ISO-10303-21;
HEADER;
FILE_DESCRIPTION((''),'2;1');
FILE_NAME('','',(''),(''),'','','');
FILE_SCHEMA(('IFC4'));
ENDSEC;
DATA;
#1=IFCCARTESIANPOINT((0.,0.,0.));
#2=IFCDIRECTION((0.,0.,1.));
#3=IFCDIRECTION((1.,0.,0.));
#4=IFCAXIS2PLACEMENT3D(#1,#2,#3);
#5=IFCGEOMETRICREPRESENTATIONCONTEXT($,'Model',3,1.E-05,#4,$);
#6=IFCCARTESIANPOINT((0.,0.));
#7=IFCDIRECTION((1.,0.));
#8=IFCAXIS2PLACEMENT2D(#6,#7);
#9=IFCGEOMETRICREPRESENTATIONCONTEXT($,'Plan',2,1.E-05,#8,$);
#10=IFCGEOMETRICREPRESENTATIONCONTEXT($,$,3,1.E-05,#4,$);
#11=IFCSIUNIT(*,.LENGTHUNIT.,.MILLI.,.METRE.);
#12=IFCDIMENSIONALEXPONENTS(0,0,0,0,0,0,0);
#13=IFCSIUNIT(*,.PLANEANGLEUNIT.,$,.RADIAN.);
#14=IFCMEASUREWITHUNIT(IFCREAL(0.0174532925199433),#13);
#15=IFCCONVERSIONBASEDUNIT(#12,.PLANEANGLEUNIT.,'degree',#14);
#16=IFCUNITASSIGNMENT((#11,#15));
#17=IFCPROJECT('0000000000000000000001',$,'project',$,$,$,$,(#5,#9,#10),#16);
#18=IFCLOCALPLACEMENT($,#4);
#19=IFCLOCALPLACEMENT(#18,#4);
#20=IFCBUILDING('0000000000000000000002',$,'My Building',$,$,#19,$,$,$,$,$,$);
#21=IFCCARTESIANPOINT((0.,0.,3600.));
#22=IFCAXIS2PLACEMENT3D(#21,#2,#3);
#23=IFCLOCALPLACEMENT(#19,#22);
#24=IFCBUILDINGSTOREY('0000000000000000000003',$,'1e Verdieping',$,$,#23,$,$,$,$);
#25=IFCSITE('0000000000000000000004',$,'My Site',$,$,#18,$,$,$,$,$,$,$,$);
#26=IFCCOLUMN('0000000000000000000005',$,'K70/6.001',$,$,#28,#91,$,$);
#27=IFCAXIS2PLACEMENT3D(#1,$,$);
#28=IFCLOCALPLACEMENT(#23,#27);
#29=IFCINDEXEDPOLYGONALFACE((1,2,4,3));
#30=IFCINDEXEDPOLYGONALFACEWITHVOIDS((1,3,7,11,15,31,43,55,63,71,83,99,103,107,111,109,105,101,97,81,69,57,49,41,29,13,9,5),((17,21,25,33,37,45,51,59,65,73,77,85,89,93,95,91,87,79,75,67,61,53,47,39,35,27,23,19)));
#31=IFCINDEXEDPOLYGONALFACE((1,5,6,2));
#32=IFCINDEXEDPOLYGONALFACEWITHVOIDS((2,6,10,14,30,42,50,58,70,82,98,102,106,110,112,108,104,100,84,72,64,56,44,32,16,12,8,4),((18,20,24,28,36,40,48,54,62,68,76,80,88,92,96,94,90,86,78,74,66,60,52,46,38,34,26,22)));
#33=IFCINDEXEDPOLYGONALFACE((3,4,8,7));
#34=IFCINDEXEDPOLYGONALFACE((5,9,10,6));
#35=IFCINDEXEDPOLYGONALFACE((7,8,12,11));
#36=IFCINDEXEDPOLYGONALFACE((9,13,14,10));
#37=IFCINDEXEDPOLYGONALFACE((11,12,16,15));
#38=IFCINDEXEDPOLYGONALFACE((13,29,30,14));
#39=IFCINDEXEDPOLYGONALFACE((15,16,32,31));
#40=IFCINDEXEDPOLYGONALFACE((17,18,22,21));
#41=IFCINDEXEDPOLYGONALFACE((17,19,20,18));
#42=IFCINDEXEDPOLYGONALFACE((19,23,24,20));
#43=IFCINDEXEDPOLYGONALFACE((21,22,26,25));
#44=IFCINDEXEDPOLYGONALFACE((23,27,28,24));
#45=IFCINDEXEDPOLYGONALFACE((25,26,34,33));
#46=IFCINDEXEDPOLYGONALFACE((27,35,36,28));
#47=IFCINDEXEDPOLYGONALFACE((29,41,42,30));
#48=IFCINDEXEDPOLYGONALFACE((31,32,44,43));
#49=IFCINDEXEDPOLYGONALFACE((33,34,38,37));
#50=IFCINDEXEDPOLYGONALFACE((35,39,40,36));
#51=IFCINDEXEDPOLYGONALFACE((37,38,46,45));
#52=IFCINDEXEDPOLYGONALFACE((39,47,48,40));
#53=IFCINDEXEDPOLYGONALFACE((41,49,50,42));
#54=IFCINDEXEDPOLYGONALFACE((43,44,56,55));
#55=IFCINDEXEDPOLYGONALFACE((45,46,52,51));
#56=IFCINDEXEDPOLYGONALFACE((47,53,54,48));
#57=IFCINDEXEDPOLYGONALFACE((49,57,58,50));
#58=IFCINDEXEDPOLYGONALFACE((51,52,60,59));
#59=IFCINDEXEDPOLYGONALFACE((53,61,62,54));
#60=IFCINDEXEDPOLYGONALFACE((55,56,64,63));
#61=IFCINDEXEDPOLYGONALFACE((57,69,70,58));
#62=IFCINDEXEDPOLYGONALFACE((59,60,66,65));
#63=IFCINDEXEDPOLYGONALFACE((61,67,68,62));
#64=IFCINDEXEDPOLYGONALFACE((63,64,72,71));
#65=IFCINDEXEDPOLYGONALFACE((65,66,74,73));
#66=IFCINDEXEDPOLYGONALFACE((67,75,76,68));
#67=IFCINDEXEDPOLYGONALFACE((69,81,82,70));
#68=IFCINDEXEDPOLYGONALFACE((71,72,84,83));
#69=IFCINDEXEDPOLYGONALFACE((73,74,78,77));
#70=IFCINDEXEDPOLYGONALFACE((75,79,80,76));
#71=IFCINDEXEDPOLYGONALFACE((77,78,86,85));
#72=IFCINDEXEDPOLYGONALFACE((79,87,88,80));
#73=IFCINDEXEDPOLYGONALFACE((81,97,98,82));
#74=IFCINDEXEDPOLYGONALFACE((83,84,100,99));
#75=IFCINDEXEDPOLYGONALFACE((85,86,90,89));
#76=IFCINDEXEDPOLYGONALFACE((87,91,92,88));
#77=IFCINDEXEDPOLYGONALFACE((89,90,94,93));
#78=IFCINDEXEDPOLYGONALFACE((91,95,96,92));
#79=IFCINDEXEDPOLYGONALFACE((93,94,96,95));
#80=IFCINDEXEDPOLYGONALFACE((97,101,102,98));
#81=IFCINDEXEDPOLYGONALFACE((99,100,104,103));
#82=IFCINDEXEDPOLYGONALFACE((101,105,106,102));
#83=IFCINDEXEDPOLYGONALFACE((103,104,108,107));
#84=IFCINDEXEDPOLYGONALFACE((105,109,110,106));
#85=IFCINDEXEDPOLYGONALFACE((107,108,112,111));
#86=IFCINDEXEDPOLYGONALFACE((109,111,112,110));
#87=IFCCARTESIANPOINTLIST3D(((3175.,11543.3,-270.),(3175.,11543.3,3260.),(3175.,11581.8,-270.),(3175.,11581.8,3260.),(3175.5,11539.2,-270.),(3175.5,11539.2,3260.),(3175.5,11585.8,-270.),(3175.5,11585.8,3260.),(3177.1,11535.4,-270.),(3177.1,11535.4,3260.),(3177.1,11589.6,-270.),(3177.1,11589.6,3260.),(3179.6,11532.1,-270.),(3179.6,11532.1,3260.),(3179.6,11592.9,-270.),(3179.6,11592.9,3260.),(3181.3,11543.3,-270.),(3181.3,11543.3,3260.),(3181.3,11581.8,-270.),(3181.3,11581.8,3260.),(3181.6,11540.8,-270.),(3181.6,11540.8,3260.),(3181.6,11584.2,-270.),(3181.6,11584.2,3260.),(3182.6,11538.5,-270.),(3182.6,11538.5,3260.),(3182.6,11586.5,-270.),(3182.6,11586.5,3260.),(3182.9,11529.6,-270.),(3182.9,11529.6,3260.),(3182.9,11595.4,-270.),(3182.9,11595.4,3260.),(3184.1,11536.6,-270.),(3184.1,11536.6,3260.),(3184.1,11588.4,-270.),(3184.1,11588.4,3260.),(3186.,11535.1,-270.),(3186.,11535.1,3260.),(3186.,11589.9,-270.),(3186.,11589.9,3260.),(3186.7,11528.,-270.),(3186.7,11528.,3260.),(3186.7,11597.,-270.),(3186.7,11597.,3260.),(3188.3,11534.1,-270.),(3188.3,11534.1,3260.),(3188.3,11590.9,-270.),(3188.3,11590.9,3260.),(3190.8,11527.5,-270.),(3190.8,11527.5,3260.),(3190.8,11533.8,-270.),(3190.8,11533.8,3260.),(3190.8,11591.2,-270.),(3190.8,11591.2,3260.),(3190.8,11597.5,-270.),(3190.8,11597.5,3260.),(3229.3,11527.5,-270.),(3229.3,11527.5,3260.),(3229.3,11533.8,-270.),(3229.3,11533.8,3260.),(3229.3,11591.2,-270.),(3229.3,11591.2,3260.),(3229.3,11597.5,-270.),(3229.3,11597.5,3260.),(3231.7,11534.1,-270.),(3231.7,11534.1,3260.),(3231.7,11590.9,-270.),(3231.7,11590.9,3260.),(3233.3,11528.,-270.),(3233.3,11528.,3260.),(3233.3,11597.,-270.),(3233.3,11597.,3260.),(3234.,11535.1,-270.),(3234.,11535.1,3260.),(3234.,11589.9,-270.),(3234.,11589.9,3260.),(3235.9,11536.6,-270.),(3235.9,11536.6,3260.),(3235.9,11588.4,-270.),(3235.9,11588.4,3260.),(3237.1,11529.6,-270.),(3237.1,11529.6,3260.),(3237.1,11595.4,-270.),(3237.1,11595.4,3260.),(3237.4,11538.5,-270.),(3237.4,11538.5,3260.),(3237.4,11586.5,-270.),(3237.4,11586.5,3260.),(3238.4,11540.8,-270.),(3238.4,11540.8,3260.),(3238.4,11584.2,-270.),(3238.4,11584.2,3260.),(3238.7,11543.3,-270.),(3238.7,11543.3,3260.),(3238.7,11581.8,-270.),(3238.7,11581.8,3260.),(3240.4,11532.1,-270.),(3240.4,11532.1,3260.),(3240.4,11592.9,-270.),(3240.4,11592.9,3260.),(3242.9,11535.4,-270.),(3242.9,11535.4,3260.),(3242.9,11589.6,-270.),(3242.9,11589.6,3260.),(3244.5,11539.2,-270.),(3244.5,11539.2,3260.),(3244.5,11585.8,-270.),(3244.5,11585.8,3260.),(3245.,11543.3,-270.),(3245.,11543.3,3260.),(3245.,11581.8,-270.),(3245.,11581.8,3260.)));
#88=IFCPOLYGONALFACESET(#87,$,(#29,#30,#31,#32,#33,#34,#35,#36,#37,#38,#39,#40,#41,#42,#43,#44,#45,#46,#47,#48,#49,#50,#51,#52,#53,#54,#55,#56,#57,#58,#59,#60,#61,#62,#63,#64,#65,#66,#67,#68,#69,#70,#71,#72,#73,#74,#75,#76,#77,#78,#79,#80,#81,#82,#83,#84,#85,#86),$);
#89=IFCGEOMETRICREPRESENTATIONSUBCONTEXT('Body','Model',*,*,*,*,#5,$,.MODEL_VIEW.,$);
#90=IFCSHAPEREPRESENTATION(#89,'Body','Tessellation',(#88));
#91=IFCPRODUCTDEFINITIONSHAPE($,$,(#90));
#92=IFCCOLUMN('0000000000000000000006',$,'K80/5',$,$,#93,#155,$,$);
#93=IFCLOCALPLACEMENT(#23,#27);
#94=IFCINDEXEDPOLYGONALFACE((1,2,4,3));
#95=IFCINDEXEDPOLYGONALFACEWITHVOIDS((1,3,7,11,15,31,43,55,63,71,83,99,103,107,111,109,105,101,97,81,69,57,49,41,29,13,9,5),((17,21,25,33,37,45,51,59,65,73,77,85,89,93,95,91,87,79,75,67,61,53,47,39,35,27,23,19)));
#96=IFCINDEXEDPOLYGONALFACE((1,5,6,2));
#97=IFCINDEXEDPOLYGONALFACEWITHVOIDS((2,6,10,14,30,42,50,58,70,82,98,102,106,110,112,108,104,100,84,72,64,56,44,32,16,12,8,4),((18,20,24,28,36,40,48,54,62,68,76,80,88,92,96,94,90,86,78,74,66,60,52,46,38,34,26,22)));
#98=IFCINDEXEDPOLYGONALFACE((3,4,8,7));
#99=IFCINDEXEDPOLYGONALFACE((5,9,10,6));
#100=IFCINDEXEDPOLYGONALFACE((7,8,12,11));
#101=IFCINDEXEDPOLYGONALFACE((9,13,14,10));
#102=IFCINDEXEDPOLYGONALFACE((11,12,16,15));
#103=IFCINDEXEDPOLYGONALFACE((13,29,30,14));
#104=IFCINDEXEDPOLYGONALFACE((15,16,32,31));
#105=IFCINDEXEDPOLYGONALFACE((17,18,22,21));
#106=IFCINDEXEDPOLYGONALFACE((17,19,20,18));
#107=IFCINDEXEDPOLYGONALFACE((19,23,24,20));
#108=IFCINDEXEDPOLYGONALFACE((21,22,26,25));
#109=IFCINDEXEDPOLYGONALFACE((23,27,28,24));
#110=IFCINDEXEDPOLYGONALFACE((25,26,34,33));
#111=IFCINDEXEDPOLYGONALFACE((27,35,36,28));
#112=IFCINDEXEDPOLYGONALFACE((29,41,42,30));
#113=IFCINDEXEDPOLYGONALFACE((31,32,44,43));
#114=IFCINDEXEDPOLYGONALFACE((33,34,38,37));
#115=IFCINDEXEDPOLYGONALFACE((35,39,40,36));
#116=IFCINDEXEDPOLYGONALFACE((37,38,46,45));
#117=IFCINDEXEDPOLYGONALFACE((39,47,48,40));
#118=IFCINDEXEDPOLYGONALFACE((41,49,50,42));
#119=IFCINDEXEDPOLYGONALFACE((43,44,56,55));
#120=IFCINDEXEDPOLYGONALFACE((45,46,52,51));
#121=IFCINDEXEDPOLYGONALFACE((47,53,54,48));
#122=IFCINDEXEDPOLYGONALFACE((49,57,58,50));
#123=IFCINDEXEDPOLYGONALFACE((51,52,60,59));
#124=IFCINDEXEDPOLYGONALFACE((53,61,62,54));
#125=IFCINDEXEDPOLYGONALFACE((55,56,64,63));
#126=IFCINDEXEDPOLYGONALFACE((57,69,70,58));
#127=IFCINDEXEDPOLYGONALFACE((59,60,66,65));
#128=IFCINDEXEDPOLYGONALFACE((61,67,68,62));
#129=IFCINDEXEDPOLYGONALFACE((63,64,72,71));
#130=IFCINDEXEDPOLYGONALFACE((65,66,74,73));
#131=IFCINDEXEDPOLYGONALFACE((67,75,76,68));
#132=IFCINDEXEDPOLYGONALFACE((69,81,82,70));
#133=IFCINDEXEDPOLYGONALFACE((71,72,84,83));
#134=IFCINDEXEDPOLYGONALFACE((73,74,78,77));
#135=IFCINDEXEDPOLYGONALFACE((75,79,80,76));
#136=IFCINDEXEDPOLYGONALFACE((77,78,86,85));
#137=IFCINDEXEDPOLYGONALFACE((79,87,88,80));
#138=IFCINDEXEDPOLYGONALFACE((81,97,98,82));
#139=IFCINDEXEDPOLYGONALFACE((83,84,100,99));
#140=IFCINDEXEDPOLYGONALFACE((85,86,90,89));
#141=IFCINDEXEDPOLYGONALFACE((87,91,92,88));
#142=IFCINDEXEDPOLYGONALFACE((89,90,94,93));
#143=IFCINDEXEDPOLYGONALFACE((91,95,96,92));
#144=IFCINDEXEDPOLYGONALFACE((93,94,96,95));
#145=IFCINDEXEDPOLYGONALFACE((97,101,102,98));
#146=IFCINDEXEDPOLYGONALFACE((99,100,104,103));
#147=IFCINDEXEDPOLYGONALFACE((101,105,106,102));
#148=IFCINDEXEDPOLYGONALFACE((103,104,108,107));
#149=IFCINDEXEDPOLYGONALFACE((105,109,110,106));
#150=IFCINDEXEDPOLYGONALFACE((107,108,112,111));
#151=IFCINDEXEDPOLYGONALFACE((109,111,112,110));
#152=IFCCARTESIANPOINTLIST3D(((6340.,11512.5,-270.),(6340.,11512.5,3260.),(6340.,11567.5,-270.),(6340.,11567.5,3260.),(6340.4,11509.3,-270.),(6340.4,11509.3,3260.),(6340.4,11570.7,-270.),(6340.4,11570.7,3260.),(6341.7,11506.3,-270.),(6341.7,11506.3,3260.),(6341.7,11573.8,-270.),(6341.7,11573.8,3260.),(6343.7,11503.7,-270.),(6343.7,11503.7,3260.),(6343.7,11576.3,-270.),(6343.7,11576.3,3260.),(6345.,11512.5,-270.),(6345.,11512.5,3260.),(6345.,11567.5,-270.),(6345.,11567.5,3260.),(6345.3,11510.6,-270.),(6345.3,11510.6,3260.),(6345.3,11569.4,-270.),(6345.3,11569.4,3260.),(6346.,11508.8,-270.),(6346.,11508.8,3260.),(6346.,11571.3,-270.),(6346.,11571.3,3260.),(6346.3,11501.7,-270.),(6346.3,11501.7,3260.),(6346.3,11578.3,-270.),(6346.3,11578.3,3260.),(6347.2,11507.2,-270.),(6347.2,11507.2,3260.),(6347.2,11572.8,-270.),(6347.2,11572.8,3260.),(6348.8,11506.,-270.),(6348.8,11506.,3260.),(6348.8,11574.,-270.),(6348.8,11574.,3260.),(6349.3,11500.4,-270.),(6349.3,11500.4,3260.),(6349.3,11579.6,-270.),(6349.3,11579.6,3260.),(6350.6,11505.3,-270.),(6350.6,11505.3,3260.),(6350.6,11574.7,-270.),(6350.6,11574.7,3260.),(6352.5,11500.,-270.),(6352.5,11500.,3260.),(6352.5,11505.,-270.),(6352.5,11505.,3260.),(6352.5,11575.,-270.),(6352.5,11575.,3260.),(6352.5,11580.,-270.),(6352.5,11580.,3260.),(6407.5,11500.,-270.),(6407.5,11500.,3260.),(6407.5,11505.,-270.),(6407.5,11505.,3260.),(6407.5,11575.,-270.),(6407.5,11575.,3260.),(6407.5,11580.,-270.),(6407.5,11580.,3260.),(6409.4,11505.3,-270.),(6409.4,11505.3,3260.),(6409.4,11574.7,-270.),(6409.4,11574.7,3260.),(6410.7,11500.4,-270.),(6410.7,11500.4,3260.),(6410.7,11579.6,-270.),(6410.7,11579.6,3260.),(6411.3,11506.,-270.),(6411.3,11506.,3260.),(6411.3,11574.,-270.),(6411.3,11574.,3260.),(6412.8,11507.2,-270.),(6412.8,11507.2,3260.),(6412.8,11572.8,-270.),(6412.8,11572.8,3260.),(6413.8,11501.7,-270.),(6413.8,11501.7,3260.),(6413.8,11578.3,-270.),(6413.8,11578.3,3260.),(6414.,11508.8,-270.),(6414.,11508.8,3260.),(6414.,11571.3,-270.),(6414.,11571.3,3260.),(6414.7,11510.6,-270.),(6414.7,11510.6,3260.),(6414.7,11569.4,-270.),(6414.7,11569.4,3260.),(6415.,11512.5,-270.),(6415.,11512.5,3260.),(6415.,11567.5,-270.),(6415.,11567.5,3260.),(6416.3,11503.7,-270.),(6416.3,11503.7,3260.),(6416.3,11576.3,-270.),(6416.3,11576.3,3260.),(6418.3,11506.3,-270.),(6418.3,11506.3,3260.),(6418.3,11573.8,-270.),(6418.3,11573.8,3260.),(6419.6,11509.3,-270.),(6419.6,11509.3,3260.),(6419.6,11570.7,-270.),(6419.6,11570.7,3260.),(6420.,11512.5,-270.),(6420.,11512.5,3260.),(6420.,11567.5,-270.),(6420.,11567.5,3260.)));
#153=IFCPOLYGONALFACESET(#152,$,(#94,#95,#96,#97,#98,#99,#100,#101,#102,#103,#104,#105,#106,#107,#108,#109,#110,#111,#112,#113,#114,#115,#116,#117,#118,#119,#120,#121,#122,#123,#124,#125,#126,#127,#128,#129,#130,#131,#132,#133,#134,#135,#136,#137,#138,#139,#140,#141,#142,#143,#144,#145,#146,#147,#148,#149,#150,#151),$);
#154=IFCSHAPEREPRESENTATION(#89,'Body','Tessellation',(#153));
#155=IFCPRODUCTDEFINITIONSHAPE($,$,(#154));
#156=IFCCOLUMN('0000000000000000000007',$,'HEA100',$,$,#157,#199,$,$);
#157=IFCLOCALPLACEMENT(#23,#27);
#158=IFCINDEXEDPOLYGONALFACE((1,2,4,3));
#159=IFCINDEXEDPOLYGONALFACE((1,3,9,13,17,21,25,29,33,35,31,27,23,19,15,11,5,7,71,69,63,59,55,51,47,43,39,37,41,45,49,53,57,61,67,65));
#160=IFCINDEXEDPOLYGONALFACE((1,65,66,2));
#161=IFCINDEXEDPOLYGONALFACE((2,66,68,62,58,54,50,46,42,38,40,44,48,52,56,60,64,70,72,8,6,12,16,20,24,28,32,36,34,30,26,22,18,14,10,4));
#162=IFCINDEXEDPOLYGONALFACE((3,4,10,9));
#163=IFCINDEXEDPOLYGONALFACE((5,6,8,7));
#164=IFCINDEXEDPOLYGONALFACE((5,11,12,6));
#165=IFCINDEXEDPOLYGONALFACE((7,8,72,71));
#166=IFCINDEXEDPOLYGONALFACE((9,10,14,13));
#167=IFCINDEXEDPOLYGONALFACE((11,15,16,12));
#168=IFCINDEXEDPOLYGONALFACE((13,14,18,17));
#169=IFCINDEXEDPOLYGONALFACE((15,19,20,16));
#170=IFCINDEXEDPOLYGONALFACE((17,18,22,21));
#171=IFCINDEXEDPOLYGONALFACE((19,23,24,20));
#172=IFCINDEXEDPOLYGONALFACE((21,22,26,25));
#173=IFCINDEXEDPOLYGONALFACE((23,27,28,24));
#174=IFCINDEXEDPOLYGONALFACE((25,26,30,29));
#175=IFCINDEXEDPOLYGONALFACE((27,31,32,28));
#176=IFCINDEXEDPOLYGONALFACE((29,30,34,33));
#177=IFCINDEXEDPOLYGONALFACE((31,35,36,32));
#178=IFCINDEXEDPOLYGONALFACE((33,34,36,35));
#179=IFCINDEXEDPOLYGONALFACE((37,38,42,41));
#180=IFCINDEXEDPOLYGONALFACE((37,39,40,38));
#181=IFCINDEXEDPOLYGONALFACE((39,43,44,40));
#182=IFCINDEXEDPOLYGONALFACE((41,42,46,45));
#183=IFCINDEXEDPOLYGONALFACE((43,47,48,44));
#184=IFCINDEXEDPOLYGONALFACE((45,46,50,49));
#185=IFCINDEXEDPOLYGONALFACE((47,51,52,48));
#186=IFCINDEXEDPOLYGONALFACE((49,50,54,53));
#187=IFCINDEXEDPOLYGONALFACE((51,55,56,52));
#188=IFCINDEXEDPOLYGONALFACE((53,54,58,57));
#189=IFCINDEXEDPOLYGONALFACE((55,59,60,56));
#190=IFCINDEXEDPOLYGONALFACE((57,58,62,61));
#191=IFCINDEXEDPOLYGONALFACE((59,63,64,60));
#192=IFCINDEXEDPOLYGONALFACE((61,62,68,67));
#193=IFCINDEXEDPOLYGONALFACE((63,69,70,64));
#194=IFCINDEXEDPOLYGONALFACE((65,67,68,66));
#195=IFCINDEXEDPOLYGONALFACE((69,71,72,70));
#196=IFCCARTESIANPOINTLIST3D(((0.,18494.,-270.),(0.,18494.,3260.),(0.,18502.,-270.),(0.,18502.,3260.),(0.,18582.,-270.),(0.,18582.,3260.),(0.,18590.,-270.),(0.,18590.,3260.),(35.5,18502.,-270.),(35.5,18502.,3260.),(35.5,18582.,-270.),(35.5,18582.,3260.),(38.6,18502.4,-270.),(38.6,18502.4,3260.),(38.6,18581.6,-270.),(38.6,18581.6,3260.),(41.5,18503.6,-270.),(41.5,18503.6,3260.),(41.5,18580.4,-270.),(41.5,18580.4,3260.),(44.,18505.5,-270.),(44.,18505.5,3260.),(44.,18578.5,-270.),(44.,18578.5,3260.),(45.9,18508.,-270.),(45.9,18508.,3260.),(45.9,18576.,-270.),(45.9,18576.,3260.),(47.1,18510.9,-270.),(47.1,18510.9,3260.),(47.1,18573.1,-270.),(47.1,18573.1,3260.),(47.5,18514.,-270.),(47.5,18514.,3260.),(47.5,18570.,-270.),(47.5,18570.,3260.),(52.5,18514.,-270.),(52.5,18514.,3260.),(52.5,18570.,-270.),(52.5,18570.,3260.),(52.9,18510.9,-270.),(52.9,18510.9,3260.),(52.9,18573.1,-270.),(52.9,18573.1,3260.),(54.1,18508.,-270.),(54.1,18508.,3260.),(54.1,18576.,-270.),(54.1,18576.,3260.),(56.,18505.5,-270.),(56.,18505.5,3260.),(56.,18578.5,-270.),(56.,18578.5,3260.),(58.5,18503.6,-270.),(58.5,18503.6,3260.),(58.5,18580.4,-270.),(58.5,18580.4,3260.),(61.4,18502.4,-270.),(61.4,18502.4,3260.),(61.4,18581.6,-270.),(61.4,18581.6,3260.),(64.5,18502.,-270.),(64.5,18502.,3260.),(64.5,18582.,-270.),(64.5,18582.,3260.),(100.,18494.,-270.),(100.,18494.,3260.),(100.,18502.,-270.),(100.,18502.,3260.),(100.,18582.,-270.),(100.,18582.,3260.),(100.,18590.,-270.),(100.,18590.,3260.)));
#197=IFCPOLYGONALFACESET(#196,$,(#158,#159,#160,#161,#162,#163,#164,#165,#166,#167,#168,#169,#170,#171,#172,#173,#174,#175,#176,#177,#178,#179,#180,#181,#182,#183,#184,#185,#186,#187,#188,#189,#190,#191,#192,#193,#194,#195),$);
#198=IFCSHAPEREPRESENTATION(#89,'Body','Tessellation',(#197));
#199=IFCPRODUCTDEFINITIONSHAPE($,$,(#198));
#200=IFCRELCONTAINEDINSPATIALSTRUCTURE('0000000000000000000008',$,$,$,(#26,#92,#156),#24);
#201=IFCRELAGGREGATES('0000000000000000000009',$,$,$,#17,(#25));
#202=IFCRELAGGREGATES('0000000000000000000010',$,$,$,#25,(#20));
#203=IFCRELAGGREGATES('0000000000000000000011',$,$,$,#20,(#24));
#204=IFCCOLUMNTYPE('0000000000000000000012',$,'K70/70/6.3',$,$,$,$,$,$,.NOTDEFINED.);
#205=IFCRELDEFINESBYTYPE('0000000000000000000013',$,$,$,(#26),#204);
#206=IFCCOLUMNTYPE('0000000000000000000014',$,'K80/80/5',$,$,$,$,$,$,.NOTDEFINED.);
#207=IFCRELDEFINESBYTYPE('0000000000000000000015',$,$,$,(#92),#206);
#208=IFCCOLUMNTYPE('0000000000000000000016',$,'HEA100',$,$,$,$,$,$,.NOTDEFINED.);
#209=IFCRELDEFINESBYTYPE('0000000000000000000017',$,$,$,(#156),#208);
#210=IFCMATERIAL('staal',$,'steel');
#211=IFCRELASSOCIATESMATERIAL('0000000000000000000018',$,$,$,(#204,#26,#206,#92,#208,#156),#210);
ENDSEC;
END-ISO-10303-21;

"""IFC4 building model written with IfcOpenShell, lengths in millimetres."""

from ifc_helpers import new_model, entity, si_unit, converted_unit, frame, origin_with_axes, origin_2d_with_axis, place, context, subcontext, project, spatial, hollow_rectangle, i_section, extrude, material, material_profile, profile_set, profile_usage, type_object, element, save


model = new_model("IFC4")

# Units and contexts
model_context = context("Model", 3, precision=1e-05, world=origin_with_axes())
plan_context = context("Plan", 2, precision=1e-05, world=origin_2d_with_axis())
context_of_model = context(None, 3, precision=1e-05, world=origin_with_axes())
body_context = subcontext(model_context, "Body", "Model", "MODEL_VIEW")
ifc_project = project(units=[si_unit("LENGTHUNIT", "METRE", prefix="MILLI"), converted_unit("PLANEANGLEUNIT", "degree", entity("IfcReal", 0.0174532925199433), si_unit("PLANEANGLEUNIT", "RADIAN"), dimensions=[0, 0, 0, 0, 0, 0, 0])], contexts=[model_context, plan_context, context_of_model])

# Site, building, storey
site_placement = place(None, origin_with_axes())
site = spatial("IfcSite", under=ifc_project, at=site_placement, Name="My Site")
building_placement = place(site_placement, origin_with_axes())
building = spatial("IfcBuilding", under=site, at=building_placement, Name="My Building")
storey_placement = place(building_placement, frame((0.0, 0.0, 3600.0), z_axis=(0.0, 0.0, 1.0), x_axis=(1.0, 0.0, 0.0)))
storey = spatial("IfcBuildingStorey", under=building, at=storey_placement, Name="1e Verdieping")

# Columns
ifc_material = material(Name="staal", Category="steel")
ifc_material_profile_1 = material_profile(ifc_material, hollow_rectangle(XDim=70.0, YDim=70.0, WallThickness=6.3, InnerFilletRadius=9.4, OuterFilletRadius=15.8))
ifc_profile_set_1 = profile_set([ifc_material_profile_1], Name="K70/70/6.3")
ifc_profile_usage_1 = profile_usage(ifc_profile_set_1)
column_type_1 = type_object("IfcColumnType", Name="K70/70/6.3", PredefinedType="NOTDEFINED", material=ifc_profile_set_1)
column_1_placement = place(storey_placement, frame((3210.0, 11562.5, -270.0), z_axis=(0.0, 0.0, 1.0), x_axis=(1.0, 0.0, 0.0)))
element("IfcColumn", 1, at=column_1_placement, inside=storey, type_object=column_type_1, material=ifc_profile_usage_1, Name="K70/6.001", context=body_context, shape_type="SweptSolid", body=[
    extrude(hollow_rectangle(XDim=70.0, YDim=70.0, WallThickness=6.3, InnerFilletRadius=9.4, OuterFilletRadius=15.8), origin_with_axes(), (0.0, 0.0, 1.0), 3530.0),
])
ifc_material_profile_2 = material_profile(ifc_material, hollow_rectangle(XDim=80.0, YDim=80.0, WallThickness=5.0, InnerFilletRadius=7.5, OuterFilletRadius=12.5))
ifc_profile_set_2 = profile_set([ifc_material_profile_2], Name="K80/80/5")
ifc_profile_usage_2 = profile_usage(ifc_profile_set_2)
column_type_2 = type_object("IfcColumnType", Name="K80/80/5", PredefinedType="NOTDEFINED", material=ifc_profile_set_2)
column_2_placement = place(storey_placement, frame((6380.0, 11540.0, -270.0), z_axis=(0.0, 0.0, 1.0), x_axis=(1.0, 0.0, 0.0)))
element("IfcColumn", 2, at=column_2_placement, inside=storey, type_object=column_type_2, material=ifc_profile_usage_2, Name="K80/5", context=body_context, shape_type="SweptSolid", body=[
    extrude(hollow_rectangle(XDim=80.0, YDim=80.0, WallThickness=5.0, InnerFilletRadius=7.5, OuterFilletRadius=12.5), origin_with_axes(), (0.0, 0.0, 1.0), 3530.0),
])
ifc_material_profile_3 = material_profile(ifc_material, i_section(OverallWidth=100.0, OverallDepth=96.0, WebThickness=5.0, FlangeThickness=8.0, FilletRadius=12.0))
ifc_profile_set_3 = profile_set([ifc_material_profile_3], Name="HEA100")
ifc_profile_usage_3 = profile_usage(ifc_profile_set_3)
column_type_3 = type_object("IfcColumnType", Name="HEA100", PredefinedType="NOTDEFINED", material=ifc_profile_set_3)
column_3_placement = place(storey_placement, frame((50.0, 18542.0, -270.0), z_axis=(0.0, 0.0, 1.0), x_axis=(1.0, 0.0, 0.0)))
element("IfcColumn", 3, at=column_3_placement, inside=storey, type_object=column_type_3, material=ifc_profile_usage_3, Name="HEA100", context=body_context, shape_type="SweptSolid", body=[
    extrude(i_section(OverallWidth=100.0, OverallDepth=96.0, WebThickness=5.0, FlangeThickness=8.0, FilletRadius=12.0), origin_with_axes(), (0.0, 0.0, 1.0), 3530.0),
])

save(model, "model.ifc")
